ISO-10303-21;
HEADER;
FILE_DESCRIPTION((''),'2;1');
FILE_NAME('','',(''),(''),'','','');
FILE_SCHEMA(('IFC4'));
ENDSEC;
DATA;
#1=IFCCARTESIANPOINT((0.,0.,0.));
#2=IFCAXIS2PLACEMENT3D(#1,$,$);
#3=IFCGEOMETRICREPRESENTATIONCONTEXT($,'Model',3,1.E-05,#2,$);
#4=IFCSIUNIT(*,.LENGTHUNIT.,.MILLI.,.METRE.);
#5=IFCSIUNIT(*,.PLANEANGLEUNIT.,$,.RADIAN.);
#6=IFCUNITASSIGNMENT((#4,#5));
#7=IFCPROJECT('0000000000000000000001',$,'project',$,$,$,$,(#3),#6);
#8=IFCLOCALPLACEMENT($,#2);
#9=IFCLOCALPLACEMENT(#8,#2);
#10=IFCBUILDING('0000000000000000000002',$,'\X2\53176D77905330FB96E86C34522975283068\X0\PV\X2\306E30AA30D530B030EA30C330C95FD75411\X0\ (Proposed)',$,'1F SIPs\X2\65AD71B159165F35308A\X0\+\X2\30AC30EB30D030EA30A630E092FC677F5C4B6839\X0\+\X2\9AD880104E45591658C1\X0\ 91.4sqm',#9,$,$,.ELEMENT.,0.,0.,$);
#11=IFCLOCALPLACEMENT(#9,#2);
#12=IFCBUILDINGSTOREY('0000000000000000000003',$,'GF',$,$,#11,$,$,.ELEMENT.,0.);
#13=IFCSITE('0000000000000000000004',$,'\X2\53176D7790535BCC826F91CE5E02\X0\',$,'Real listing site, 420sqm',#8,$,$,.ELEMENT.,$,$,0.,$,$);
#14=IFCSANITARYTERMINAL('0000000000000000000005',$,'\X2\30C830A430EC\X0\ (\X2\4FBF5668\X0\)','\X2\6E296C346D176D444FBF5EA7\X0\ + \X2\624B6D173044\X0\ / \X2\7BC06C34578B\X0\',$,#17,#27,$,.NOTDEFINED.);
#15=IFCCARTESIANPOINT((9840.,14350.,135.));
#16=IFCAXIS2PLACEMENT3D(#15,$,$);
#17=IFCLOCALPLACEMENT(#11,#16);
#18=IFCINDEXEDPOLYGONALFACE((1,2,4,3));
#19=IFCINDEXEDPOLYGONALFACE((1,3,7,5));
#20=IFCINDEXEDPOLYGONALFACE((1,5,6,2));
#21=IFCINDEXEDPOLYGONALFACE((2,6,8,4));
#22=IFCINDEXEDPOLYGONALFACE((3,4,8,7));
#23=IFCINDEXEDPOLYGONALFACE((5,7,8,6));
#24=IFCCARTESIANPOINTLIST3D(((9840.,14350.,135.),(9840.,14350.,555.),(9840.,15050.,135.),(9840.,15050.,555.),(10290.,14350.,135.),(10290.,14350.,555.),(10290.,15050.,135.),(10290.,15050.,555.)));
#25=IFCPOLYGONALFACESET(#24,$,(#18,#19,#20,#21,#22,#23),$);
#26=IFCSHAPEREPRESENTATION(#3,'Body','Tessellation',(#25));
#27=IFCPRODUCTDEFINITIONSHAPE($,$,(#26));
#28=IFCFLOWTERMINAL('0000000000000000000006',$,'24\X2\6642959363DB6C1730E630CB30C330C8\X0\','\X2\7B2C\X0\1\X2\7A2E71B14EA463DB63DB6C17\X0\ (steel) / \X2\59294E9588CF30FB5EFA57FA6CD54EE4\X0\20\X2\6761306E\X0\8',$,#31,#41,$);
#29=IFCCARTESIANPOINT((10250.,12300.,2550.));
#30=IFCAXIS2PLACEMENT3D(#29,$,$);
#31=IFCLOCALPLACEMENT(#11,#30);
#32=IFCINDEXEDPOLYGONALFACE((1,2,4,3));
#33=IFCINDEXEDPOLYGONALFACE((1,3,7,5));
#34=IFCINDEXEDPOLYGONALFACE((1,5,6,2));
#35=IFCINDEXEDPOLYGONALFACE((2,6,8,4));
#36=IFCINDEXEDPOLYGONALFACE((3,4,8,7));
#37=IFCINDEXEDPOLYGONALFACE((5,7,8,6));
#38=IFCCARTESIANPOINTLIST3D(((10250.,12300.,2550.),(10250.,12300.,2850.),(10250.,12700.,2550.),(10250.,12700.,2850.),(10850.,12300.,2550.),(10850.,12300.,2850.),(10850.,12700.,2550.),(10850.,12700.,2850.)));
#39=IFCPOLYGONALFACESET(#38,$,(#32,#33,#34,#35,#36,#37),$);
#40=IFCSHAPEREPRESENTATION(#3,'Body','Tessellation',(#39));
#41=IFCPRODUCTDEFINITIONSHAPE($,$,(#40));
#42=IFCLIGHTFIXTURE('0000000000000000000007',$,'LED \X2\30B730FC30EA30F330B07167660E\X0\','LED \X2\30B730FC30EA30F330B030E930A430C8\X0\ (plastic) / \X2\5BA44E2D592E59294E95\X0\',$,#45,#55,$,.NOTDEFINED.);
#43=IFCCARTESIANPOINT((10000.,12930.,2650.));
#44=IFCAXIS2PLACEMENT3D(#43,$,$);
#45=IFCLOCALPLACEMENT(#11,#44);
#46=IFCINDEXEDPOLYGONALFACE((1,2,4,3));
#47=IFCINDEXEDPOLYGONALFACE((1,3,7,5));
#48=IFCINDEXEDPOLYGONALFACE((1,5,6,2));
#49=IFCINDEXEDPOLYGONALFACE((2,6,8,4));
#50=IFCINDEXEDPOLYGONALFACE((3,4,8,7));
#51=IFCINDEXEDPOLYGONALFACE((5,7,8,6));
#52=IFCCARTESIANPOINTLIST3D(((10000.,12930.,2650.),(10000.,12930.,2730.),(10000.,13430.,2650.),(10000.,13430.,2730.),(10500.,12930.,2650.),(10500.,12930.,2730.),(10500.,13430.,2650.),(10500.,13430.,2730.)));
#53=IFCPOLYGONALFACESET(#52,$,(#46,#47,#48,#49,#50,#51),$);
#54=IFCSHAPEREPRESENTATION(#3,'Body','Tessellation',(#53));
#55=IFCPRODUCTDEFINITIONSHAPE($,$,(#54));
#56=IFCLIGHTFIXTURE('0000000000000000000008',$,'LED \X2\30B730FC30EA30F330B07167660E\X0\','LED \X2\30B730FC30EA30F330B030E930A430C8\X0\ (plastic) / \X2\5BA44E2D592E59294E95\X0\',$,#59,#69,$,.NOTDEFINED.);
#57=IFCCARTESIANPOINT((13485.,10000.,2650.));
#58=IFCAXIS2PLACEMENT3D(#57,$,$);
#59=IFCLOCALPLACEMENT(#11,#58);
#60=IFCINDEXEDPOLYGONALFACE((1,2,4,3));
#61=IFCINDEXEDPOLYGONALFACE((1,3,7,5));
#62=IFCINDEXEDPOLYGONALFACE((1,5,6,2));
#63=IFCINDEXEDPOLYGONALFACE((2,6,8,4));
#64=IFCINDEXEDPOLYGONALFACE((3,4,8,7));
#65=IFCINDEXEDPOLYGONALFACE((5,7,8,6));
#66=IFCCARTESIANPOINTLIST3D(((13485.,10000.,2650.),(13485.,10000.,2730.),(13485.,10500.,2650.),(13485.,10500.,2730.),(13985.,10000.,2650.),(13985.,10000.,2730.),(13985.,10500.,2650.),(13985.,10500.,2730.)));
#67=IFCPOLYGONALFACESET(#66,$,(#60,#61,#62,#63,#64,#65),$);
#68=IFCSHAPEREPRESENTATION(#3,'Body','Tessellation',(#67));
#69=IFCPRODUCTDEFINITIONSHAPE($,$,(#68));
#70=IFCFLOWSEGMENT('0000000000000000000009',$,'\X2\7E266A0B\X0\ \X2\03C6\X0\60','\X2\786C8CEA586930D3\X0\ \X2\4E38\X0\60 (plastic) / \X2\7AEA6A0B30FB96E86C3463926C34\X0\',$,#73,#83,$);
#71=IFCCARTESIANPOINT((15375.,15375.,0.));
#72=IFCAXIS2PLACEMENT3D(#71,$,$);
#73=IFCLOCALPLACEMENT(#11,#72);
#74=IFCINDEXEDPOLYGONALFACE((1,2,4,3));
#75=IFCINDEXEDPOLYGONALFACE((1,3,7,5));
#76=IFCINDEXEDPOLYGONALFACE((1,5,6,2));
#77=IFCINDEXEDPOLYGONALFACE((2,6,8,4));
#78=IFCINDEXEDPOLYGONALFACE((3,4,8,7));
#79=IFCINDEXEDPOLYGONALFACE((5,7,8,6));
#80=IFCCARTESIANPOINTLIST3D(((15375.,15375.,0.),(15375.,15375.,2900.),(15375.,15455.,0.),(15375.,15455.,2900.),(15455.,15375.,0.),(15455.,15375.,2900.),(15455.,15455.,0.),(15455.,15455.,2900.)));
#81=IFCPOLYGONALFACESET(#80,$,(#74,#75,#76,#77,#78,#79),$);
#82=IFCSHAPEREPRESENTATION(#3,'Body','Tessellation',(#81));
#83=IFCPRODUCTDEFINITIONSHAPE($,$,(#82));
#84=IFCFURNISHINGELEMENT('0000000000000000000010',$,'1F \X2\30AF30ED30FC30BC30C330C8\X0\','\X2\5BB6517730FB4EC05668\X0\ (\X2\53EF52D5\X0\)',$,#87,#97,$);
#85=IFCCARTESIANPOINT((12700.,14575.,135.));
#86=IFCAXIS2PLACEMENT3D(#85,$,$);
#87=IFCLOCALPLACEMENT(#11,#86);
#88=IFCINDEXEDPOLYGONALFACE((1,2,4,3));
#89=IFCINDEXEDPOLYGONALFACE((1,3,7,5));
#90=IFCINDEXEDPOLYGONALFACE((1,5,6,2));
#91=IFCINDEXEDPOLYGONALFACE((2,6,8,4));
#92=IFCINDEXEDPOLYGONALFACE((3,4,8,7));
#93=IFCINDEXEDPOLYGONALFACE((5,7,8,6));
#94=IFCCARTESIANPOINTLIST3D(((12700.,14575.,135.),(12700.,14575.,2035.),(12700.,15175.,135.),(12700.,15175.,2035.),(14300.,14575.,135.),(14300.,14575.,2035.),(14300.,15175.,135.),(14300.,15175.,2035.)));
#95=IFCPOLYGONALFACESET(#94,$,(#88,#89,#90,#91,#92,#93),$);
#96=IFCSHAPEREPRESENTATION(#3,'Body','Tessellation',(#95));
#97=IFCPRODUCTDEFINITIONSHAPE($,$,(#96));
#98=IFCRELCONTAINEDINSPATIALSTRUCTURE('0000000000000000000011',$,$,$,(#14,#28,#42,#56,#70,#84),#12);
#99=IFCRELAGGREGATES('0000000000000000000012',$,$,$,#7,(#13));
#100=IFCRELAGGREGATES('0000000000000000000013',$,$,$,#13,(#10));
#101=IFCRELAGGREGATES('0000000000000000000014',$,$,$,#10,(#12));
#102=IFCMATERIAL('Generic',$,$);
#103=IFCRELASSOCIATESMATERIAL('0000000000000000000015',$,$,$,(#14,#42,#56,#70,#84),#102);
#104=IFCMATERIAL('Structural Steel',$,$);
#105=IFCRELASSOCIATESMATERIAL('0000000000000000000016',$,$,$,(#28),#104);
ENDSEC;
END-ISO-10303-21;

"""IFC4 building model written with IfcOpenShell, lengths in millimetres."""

from ifc_helpers import new_model, si_unit, frame, frame_2d, origin, place, context, project, spatial, rectangle, extrude, material, element, save


model = new_model("IFC4")

# Units and contexts
model_context = context("Model", 3, precision=1e-05, world=origin())
ifc_project = project(units=[si_unit("LENGTHUNIT", "METRE", prefix="MILLI"), si_unit("PLANEANGLEUNIT", "RADIAN")], contexts=[model_context])

# Site, building, storey
site_placement = place(None, origin())
site = spatial("IfcSite", under=ifc_project, at=site_placement, Name="北海道富良野市", ObjectType="Real listing site, 420sqm", CompositionType="ELEMENT", RefElevation=0.0)
building_placement = place(site_placement, origin())
building = spatial("IfcBuilding", under=site, at=building_placement, Name="北海道・雨水利用とPVのオフグリッド志向 (Proposed)", ObjectType="1F SIPs断熱外張り+ガルバリウム鋼板屋根+高耐久外壁 91.4sqm", CompositionType="ELEMENT", ElevationOfRefHeight=0.0, ElevationOfTerrain=0.0)
storey_placement = place(building_placement, origin())
storey = spatial("IfcBuildingStorey", under=building, at=storey_placement, Name="GF", CompositionType="ELEMENT", Elevation=0.0)

# Shared definitions
ifc_material_1 = material(Name="Generic")

# Sanitary terminal
sanitary_terminal_placement = place(storey_placement, frame((9840.0, 14350.0, 135.0)))
element("IfcSanitaryTerminal", 1, at=sanitary_terminal_placement, inside=storey, material=ifc_material_1, Name="トイレ (便器)", Description="温水洗浄便座 + 手洗い / 節水型", PredefinedType="NOTDEFINED", context=model_context, shape_type="SweptSolid", body=[
    extrude(rectangle(XDim=450.0, YDim=700.0, at=frame_2d((225.0, 350.0))), frame((9840.0, 14350.0, 135.0)), (0.0, 0.0, 1.0), 420.0),
])

# Flow terminal
ifc_material_2 = material(Name="Structural Steel")
flow_terminal_placement = place(storey_placement, frame((10250.0, 12300.0, 2550.0)))
element("IfcFlowTerminal", 2, at=flow_terminal_placement, inside=storey, material=ifc_material_2, Name="24時間換気ユニット", Description="第1種熱交換換気 (steel) / 天井裏・建基法令20条の8", context=model_context, shape_type="SweptSolid", body=[
    extrude(rectangle(XDim=600.0, YDim=400.0, at=frame_2d((300.0, 200.0))), frame((10250.0, 12300.0, 2550.0)), (0.0, 0.0, 1.0), 300.0),
])

# Light fixtures
light_fixture_1_placement = place(storey_placement, frame((10000.0, 12930.0, 2650.0)))
element("IfcLightFixture", 3, at=light_fixture_1_placement, inside=storey, material=ifc_material_1, Name="LED シーリング照明", Description="LED シーリングライト (plastic) / 室中央天井", PredefinedType="NOTDEFINED", context=model_context, shape_type="SweptSolid", body=[
    extrude(rectangle(XDim=500.0, YDim=500.0, at=frame_2d((250.0, 250.0))), frame((10000.0, 12930.0, 2650.0)), (0.0, 0.0, 1.0), 80.0),
])
light_fixture_2_placement = place(storey_placement, frame((13485.0, 10000.0, 2650.0)))
element("IfcLightFixture", 4, at=light_fixture_2_placement, inside=storey, material=ifc_material_1, Name="LED シーリング照明", Description="LED シーリングライト (plastic) / 室中央天井", PredefinedType="NOTDEFINED", context=model_context, shape_type="SweptSolid", body=[
    extrude(rectangle(XDim=500.0, YDim=500.0, at=frame_2d((250.0, 250.0))), frame((13485.0, 10000.0, 2650.0)), (0.0, 0.0, 1.0), 80.0),
])

# Flow segment
flow_segment_placement = place(storey_placement, frame((15375.0, 15375.0, 0.0)))
element("IfcFlowSegment", 5, at=flow_segment_placement, inside=storey, material=ifc_material_1, Name="縦樋 φ60", Description="硬質塩ビ 丸60 (plastic) / 竪樋・雨水排水", context=model_context, shape_type="SweptSolid", body=[
    extrude(rectangle(XDim=80.0, YDim=80.0, at=frame_2d((40.0, 40.0))), frame((15375.0, 15375.0, 0.0)), (0.0, 0.0, 1.0), 2900.0),
])

# Furnishing element
furnishing_placement = place(storey_placement, frame((12700.0, 14575.0, 135.0)))
element("IfcFurnishingElement", 6, at=furnishing_placement, inside=storey, material=ifc_material_1, Name="1F クローゼット", Description="家具・什器 (可動)", context=model_context, shape_type="SweptSolid", body=[
    extrude(rectangle(XDim=1600.0, YDim=600.0, at=frame_2d((800.0, 300.0))), frame((12700.0, 14575.0, 135.0)), (0.0, 0.0, 1.0), 1900.0),
])

save(model, "model.ifc")
